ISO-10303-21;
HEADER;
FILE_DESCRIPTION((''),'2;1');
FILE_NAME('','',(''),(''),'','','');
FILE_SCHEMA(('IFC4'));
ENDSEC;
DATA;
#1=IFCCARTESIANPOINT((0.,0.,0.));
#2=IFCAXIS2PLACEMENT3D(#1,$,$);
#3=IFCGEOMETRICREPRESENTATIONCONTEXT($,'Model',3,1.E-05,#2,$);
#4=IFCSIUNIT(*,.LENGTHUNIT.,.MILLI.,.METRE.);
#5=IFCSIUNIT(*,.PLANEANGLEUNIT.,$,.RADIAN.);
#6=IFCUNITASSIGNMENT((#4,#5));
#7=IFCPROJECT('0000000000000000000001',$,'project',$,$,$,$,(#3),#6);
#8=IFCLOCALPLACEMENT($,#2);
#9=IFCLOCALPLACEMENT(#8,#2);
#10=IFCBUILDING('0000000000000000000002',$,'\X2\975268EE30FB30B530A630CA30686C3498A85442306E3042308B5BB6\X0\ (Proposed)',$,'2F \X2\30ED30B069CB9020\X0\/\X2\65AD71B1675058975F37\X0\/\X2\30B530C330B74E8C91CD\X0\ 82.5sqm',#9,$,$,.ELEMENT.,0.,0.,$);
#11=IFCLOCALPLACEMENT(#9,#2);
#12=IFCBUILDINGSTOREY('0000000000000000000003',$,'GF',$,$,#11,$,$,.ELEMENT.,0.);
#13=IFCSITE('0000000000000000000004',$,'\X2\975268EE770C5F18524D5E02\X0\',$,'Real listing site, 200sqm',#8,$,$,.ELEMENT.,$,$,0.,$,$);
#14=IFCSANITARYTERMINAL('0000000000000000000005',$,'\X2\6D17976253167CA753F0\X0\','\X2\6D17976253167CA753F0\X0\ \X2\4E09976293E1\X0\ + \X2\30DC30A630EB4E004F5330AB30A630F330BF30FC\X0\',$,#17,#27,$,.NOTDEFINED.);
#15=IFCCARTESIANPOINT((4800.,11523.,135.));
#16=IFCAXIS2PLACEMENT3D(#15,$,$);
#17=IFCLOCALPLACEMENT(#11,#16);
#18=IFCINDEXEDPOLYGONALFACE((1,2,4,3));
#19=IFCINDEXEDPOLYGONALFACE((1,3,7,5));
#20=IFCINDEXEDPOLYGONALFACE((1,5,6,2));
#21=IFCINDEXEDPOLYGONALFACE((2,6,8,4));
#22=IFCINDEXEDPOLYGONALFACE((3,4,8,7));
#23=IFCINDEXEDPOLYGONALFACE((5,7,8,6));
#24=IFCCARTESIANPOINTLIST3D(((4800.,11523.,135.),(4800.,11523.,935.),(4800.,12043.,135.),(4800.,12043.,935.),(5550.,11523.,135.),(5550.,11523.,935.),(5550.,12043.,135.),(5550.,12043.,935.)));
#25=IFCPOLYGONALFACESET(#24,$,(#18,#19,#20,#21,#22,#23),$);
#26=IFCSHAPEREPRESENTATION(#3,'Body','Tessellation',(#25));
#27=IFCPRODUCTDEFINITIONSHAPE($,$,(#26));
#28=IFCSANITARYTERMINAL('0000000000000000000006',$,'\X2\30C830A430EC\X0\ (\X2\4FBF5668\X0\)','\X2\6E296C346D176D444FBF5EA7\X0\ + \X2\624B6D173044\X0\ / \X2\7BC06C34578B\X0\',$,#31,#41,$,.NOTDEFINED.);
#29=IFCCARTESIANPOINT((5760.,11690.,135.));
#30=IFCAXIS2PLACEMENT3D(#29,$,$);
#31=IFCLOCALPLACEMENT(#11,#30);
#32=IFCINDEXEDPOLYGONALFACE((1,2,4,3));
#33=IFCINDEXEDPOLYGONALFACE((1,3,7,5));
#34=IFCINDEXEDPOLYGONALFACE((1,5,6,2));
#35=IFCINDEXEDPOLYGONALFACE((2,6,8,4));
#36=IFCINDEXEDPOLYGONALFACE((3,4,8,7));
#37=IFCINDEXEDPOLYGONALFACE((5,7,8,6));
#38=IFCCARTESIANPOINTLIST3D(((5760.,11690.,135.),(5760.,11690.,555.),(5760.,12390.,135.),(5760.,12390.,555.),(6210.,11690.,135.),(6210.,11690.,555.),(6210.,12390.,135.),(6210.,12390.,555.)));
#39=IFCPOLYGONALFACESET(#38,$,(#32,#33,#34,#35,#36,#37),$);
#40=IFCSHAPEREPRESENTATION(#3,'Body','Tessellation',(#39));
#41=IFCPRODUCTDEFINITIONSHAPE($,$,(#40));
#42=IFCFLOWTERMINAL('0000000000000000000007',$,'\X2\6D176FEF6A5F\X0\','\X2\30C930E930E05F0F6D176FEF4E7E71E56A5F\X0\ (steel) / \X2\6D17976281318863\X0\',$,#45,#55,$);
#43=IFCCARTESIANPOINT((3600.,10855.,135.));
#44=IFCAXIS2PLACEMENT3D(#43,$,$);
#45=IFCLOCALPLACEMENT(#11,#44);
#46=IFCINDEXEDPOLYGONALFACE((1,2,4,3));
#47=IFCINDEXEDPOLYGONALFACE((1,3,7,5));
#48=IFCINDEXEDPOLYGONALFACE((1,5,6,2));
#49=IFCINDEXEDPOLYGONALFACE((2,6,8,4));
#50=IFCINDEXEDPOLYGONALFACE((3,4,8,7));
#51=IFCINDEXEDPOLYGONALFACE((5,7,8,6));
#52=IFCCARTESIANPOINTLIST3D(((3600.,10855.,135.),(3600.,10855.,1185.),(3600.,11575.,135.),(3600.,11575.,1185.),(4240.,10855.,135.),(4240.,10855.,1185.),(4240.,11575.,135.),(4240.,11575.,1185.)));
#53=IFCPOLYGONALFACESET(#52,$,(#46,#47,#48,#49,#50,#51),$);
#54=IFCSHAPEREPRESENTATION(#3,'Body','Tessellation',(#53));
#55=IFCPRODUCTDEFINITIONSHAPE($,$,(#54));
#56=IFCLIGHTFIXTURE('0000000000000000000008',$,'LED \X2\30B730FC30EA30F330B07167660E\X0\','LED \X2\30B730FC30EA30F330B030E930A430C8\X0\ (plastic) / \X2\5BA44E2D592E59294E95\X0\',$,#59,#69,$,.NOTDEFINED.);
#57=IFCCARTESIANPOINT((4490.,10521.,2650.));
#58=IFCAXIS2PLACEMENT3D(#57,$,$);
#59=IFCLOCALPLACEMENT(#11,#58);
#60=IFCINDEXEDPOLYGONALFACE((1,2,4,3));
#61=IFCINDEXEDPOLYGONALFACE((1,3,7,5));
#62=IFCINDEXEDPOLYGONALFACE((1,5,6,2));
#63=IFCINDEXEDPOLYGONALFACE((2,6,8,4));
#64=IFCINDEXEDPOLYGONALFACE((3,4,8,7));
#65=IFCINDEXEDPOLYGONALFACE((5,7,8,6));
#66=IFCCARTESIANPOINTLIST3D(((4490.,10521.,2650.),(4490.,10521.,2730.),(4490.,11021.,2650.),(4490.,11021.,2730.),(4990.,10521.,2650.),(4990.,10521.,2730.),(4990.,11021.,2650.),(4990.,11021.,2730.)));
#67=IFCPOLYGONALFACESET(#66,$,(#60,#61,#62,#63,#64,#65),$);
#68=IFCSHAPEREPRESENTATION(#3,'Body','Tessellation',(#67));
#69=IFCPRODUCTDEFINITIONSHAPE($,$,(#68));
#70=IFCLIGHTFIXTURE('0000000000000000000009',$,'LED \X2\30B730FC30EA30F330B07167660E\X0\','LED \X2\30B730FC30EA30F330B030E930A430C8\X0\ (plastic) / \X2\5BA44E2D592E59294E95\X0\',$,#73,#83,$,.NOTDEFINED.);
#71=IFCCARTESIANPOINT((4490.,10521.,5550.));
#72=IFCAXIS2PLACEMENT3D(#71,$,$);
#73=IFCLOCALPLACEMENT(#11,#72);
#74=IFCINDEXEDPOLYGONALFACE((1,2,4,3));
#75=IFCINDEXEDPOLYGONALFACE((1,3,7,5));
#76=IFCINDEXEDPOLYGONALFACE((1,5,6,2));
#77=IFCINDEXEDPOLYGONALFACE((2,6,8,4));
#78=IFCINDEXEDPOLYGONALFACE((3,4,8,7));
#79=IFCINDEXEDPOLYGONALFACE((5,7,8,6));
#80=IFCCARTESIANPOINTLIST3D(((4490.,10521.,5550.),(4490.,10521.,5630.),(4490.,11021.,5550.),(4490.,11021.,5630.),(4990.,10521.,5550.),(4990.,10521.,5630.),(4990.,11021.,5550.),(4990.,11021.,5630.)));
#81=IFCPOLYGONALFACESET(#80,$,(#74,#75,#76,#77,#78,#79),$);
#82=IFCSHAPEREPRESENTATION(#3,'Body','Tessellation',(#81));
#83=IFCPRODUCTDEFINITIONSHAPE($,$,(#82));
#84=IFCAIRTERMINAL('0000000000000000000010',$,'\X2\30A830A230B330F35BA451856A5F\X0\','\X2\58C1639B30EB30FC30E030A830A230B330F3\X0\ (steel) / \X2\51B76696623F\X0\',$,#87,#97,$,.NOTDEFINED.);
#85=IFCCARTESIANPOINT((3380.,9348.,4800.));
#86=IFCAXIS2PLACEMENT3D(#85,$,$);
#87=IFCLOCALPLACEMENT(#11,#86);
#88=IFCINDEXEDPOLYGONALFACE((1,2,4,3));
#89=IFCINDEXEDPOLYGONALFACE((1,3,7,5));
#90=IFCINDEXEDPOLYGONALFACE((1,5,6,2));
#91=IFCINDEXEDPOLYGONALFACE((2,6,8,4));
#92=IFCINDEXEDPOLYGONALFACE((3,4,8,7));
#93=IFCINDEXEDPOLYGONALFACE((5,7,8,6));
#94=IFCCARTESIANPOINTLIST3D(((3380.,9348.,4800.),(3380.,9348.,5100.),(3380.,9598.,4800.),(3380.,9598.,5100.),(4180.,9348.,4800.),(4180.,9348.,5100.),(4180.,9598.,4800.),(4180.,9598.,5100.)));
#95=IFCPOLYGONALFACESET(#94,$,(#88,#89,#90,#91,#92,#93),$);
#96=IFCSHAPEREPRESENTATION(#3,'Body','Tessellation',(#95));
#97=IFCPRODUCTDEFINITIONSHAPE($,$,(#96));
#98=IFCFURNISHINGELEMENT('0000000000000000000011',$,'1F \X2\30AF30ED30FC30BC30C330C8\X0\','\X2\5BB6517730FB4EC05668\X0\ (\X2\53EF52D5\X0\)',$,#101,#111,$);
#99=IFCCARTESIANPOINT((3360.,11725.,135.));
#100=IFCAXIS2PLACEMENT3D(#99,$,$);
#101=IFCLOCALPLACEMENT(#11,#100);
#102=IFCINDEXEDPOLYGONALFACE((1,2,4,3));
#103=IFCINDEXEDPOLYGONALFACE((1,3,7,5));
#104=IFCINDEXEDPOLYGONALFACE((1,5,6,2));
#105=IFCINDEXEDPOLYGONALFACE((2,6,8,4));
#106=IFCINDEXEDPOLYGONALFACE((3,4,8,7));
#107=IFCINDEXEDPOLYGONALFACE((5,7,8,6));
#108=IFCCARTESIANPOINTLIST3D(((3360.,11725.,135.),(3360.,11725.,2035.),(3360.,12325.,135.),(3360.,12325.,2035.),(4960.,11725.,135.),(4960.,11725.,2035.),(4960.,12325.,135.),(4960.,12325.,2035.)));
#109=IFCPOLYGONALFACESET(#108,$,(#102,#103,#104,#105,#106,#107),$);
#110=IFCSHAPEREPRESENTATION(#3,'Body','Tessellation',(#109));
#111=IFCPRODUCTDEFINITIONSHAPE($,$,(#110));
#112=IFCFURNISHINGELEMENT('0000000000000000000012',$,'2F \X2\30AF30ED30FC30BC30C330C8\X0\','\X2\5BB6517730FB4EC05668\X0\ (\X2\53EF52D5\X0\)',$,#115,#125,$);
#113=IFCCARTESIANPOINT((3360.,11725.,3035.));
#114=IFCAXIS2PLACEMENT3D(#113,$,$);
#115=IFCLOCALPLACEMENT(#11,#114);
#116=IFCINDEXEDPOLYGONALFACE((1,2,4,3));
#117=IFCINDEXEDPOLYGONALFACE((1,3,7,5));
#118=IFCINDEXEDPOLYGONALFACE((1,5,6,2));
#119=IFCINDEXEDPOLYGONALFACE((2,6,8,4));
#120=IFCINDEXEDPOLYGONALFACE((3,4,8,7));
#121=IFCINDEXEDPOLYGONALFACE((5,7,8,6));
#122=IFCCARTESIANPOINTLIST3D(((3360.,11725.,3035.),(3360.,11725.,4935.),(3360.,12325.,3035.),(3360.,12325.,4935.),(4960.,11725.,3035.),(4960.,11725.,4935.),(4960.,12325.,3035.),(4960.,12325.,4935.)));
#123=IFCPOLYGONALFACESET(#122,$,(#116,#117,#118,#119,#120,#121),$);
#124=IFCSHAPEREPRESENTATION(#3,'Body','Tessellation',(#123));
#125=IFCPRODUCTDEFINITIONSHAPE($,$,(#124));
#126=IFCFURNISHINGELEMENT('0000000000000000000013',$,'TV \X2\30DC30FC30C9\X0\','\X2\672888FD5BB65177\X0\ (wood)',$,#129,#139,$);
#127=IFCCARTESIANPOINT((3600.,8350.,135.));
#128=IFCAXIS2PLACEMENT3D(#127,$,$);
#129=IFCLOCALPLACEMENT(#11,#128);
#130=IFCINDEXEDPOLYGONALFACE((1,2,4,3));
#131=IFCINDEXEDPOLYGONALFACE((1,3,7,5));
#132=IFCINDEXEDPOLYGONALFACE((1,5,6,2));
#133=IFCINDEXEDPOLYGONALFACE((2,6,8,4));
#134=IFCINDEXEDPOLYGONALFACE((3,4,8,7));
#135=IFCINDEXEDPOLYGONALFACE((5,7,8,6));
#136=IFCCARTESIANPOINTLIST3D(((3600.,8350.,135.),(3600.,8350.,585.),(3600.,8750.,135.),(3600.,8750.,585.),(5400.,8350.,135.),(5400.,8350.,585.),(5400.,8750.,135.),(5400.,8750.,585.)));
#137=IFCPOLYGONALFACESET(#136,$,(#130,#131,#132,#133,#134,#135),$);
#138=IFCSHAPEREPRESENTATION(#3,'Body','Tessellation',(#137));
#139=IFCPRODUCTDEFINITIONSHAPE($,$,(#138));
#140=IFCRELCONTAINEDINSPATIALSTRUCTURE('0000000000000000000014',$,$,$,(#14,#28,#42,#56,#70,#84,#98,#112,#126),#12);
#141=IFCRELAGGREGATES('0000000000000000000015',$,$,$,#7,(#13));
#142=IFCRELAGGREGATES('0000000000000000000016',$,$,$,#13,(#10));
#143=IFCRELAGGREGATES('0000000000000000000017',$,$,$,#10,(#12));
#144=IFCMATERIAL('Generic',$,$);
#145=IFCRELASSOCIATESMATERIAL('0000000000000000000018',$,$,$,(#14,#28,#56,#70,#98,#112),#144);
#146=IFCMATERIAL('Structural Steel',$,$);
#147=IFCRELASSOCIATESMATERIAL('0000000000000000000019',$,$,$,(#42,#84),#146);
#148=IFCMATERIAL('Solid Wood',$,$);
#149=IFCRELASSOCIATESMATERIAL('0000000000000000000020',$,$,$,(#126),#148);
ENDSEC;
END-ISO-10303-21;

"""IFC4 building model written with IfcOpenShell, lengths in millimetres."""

from ifc_helpers import new_model, si_unit, frame, frame_2d, origin, place, context, project, spatial, rectangle, extrude, material, element, save


model = new_model("IFC4")

# Units and contexts
model_context = context("Model", 3, precision=1e-05, world=origin())
ifc_project = project(units=[si_unit("LENGTHUNIT", "METRE", prefix="MILLI"), si_unit("PLANEANGLEUNIT", "RADIAN")], contexts=[model_context])

# Site, building, storey
site_placement = place(None, origin())
site = spatial("IfcSite", under=ifc_project, at=site_placement, Name="青森県弘前市", ObjectType="Real listing site, 200sqm", CompositionType="ELEMENT", RefElevation=0.0)
building_placement = place(site_placement, origin())
building = spatial("IfcBuilding", under=site, at=building_placement, Name="青森・サウナと水風呂のある家 (Proposed)", ObjectType="2F ログ構造/断熱材増強/サッシ二重 82.5sqm", CompositionType="ELEMENT", ElevationOfRefHeight=0.0, ElevationOfTerrain=0.0)
storey_placement = place(building_placement, origin())
storey = spatial("IfcBuildingStorey", under=building, at=storey_placement, Name="GF", CompositionType="ELEMENT", Elevation=0.0)

# Shared definitions
ifc_material_1 = material(Name="Solid Wood")

# Sanitary terminals
ifc_material_2 = material(Name="Generic")
sanitary_terminal_1_placement = place(storey_placement, frame((4800.0, 11523.0, 135.0)))
element("IfcSanitaryTerminal", 1, at=sanitary_terminal_1_placement, inside=storey, material=ifc_material_2, Name="洗面化粧台", Description="洗面化粧台 三面鏡 + ボウル一体カウンター", PredefinedType="NOTDEFINED", context=model_context, shape_type="SweptSolid", body=[
    extrude(rectangle(XDim=750.0, YDim=520.0, at=frame_2d((375.0, 260.0))), frame((4800.0, 11523.0, 135.0)), (0.0, 0.0, 1.0), 800.0),
])
sanitary_terminal_2_placement = place(storey_placement, frame((5760.0, 11690.0, 135.0)))
element("IfcSanitaryTerminal", 2, at=sanitary_terminal_2_placement, inside=storey, material=ifc_material_2, Name="トイレ (便器)", Description="温水洗浄便座 + 手洗い / 節水型", PredefinedType="NOTDEFINED", context=model_context, shape_type="SweptSolid", body=[
    extrude(rectangle(XDim=450.0, YDim=700.0, at=frame_2d((225.0, 350.0))), frame((5760.0, 11690.0, 135.0)), (0.0, 0.0, 1.0), 420.0),
])

# Flow terminal
ifc_material_3 = material(Name="Structural Steel")
flow_terminal_placement = place(storey_placement, frame((3600.0, 10855.0, 135.0)))
element("IfcFlowTerminal", 3, at=flow_terminal_placement, inside=storey, material=ifc_material_3, Name="洗濯機", Description="ドラム式洗濯乾燥機 (steel) / 洗面脱衣", context=model_context, shape_type="SweptSolid", body=[
    extrude(rectangle(XDim=640.0, YDim=720.0, at=frame_2d((320.0, 360.0))), frame((3600.0, 10855.0, 135.0)), (0.0, 0.0, 1.0), 1050.0),
])

# Light fixtures
light_fixture_1_placement = place(storey_placement, frame((4490.0, 10521.0, 2650.0)))
element("IfcLightFixture", 4, at=light_fixture_1_placement, inside=storey, material=ifc_material_2, Name="LED シーリング照明", Description="LED シーリングライト (plastic) / 室中央天井", PredefinedType="NOTDEFINED", context=model_context, shape_type="SweptSolid", body=[
    extrude(rectangle(XDim=500.0, YDim=500.0, at=frame_2d((250.0, 250.0))), frame((4490.0, 10521.0, 2650.0)), (0.0, 0.0, 1.0), 80.0),
])
light_fixture_2_placement = place(storey_placement, frame((4490.0, 10521.0, 5550.0)))
element("IfcLightFixture", 5, at=light_fixture_2_placement, inside=storey, material=ifc_material_2, Name="LED シーリング照明", Description="LED シーリングライト (plastic) / 室中央天井", PredefinedType="NOTDEFINED", context=model_context, shape_type="SweptSolid", body=[
    extrude(rectangle(XDim=500.0, YDim=500.0, at=frame_2d((250.0, 250.0))), frame((4490.0, 10521.0, 5550.0)), (0.0, 0.0, 1.0), 80.0),
])

# Air terminal
air_terminal_placement = place(storey_placement, frame((3380.0, 9348.0, 4800.0)))
element("IfcAirTerminal", 6, at=air_terminal_placement, inside=storey, material=ifc_material_3, Name="エアコン室内機", Description="壁掛ルームエアコン (steel) / 冷暖房", PredefinedType="NOTDEFINED", context=model_context, shape_type="SweptSolid", body=[
    extrude(rectangle(XDim=800.0, YDim=250.0, at=frame_2d((400.0, 125.0))), frame((3380.0, 9348.0, 4800.0)), (0.0, 0.0, 1.0), 300.0),
])

# Furnishing elements
furnishing_1_placement = place(storey_placement, frame((3360.0, 11725.0, 135.0)))
element("IfcFurnishingElement", 7, at=furnishing_1_placement, inside=storey, material=ifc_material_2, Name="1F クローゼット", Description="家具・什器 (可動)", context=model_context, shape_type="SweptSolid", body=[
    extrude(rectangle(XDim=1600.0, YDim=600.0, at=frame_2d((800.0, 300.0))), frame((3360.0, 11725.0, 135.0)), (0.0, 0.0, 1.0), 1900.0),
])
furnishing_2_placement = place(storey_placement, frame((3360.0, 11725.0, 3035.0)))
element("IfcFurnishingElement", 8, at=furnishing_2_placement, inside=storey, material=ifc_material_2, Name="2F クローゼット", Description="家具・什器 (可動)", context=model_context, shape_type="SweptSolid", body=[
    extrude(rectangle(XDim=1600.0, YDim=600.0, at=frame_2d((800.0, 300.0))), frame((3360.0, 11725.0, 3035.0)), (0.0, 0.0, 1.0), 1900.0),
])
furnishing_3_placement = place(storey_placement, frame((3600.0, 8350.0, 135.0)))
element("IfcFurnishingElement", 9, at=furnishing_3_placement, inside=storey, material=ifc_material_1, Name="TV ボード", Description="木製家具 (wood)", context=model_context, shape_type="SweptSolid", body=[
    extrude(rectangle(XDim=1800.0, YDim=400.0, at=frame_2d((900.0, 200.0))), frame((3600.0, 8350.0, 135.0)), (0.0, 0.0, 1.0), 450.0),
])

save(model, "model.ifc")
